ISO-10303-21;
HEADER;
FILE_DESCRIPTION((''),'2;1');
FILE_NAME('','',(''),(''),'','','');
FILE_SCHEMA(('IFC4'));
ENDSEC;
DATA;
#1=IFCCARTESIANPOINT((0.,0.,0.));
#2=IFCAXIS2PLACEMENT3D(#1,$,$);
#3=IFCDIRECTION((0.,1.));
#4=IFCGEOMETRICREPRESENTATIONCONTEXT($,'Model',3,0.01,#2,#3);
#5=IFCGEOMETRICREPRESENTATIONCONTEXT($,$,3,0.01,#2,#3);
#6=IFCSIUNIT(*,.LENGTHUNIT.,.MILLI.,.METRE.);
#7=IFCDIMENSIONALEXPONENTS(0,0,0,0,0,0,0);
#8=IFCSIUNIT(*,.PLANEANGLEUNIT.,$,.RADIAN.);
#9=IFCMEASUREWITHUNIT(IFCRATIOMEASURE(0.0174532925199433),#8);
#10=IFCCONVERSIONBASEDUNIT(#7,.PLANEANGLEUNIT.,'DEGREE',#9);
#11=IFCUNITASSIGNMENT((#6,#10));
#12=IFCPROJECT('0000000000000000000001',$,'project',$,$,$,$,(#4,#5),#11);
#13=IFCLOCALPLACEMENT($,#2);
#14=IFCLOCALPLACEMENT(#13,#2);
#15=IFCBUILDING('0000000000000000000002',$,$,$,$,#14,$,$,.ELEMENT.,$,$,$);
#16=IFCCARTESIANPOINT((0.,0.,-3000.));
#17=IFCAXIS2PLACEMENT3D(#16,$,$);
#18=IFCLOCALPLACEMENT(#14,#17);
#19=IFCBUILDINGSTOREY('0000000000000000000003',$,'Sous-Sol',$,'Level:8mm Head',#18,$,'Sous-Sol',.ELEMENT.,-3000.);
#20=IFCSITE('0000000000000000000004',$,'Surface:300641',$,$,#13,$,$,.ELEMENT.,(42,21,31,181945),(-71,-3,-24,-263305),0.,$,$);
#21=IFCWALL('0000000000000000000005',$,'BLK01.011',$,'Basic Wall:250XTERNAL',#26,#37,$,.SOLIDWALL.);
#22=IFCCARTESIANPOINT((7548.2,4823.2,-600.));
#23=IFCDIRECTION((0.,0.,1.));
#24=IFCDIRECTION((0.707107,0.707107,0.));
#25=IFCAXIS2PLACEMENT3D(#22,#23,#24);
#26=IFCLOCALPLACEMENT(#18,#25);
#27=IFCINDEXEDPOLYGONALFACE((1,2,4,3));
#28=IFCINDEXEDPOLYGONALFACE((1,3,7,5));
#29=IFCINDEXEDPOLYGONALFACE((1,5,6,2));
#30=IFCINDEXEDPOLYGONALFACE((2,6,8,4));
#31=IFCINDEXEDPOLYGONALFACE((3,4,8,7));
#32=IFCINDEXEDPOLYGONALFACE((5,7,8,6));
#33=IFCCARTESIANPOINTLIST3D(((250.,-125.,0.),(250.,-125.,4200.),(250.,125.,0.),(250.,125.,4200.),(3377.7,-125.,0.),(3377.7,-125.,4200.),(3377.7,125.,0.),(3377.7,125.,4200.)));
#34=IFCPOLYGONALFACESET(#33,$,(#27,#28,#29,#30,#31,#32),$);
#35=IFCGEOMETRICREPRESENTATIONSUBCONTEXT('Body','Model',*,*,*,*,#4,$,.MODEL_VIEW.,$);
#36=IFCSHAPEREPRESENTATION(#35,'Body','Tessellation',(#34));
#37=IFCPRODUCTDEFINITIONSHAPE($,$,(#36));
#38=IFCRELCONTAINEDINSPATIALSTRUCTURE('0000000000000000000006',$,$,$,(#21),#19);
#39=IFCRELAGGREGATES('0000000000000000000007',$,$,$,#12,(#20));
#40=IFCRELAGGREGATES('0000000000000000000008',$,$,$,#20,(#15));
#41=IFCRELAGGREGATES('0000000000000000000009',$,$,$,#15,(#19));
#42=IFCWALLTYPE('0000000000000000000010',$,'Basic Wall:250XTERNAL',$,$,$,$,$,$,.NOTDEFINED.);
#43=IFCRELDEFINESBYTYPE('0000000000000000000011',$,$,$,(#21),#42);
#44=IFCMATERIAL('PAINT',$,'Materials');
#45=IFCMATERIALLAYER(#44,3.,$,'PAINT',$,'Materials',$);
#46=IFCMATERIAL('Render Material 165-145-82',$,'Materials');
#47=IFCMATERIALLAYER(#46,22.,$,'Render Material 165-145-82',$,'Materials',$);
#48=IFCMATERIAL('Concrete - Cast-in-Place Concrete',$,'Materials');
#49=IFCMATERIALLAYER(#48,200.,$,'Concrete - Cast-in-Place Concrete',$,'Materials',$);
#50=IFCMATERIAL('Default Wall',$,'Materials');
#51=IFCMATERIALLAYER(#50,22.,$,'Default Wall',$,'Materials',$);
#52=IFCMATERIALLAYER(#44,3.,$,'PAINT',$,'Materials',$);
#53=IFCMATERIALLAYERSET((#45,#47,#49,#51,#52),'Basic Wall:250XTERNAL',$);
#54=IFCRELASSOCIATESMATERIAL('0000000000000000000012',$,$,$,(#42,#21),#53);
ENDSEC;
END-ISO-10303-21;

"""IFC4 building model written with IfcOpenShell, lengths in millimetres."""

from ifc_helpers import new_model, entity, si_unit, converted_unit, direction, frame, frame_2d, origin, place, context, subcontext, project, spatial, rectangle, extrude, material, layer, layer_set, layer_usage, type_object, element, save


model = new_model("IFC4")

# Units and contexts
model_context = context("Model", 3, precision=0.01, world=origin(), true_north=direction((0.0, 1.0)))
context_of_model = context(None, 3, precision=0.01, world=origin(), true_north=direction((0.0, 1.0)))
body_context = subcontext(model_context, "Body", "Model", "MODEL_VIEW")
ifc_project = project(units=[si_unit("LENGTHUNIT", "METRE", prefix="MILLI"), converted_unit("PLANEANGLEUNIT", "DEGREE", entity("IfcRatioMeasure", 0.0174532925199433), si_unit("PLANEANGLEUNIT", "RADIAN"), dimensions=[0, 0, 0, 0, 0, 0, 0])], contexts=[model_context, context_of_model])

# Site, building, storey
site_placement = place(None, origin())
site = spatial("IfcSite", under=ifc_project, at=site_placement, Name="Surface:300641", CompositionType="ELEMENT", RefLatitude=(42, 21, 31, 181945), RefLongitude=(-71, -3, -24, -263305), RefElevation=0.0)
building_placement = place(site_placement, origin())
building = spatial("IfcBuilding", under=site, at=building_placement, CompositionType="ELEMENT")
storey_placement = place(building_placement, frame((0.0, 0.0, -3000.0)))
storey = spatial("IfcBuildingStorey", under=building, at=storey_placement, Name="Sous-Sol", ObjectType="Level:8mm Head", LongName="Sous-Sol", CompositionType="ELEMENT", Elevation=-3000.0)

# Shared definitions
ifc_material_1 = material(Name="Concrete - Cast-in-Place Concrete", Category="Materials")

# Wall
ifc_material_2 = material(Name="PAINT", Category="Materials")
ifc_layer_1 = layer(ifc_material_2, 3.0, Name="PAINT", Category="Materials")
ifc_material_3 = material(Name="Render Material 165-145-82", Category="Materials")
ifc_layer_2 = layer(ifc_material_3, 22.0, Name="Render Material 165-145-82", Category="Materials")
ifc_layer_3 = layer(ifc_material_1, 200.0, Name="Concrete - Cast-in-Place Concrete", Category="Materials")
ifc_material_4 = material(Name="Default Wall", Category="Materials")
ifc_layer_4 = layer(ifc_material_4, 22.0, Name="Default Wall", Category="Materials")
ifc_layer_5 = layer(ifc_material_2, 3.0, Name="PAINT", Category="Materials")
ifc_layer_set = layer_set([ifc_layer_1, ifc_layer_2, ifc_layer_3, ifc_layer_4, ifc_layer_5], Name="Basic Wall:250XTERNAL")
wall_type = type_object("IfcWallType", Name="Basic Wall:250XTERNAL", PredefinedType="NOTDEFINED", material=ifc_layer_set)
ifc_layer_usage_1 = layer_usage(ifc_layer_set, "AXIS2", "POSITIVE", -125.0)
wall_1_placement = place(storey_placement, frame((7548.2, 4823.2, -600.0), z_axis=(0.0, 0.0, 1.0), x_axis=(0.707107, 0.707107, 0.0)))
element("IfcWall", 1, at=wall_1_placement, inside=storey, type_object=wall_type, material=ifc_layer_usage_1, Name="BLK01.011", ObjectType="Basic Wall:250XTERNAL", PredefinedType="SOLIDWALL", context=body_context, shape_type="SweptSolid", body=[
    extrude(rectangle(XDim=3127.7, YDim=250.0, at=frame_2d((1813.8, 0.0), x_axis=(-1.0, 0.0))), origin(), (0.0, 0.0, 1.0), 4200.0),
])

save(model, "model.ifc")
